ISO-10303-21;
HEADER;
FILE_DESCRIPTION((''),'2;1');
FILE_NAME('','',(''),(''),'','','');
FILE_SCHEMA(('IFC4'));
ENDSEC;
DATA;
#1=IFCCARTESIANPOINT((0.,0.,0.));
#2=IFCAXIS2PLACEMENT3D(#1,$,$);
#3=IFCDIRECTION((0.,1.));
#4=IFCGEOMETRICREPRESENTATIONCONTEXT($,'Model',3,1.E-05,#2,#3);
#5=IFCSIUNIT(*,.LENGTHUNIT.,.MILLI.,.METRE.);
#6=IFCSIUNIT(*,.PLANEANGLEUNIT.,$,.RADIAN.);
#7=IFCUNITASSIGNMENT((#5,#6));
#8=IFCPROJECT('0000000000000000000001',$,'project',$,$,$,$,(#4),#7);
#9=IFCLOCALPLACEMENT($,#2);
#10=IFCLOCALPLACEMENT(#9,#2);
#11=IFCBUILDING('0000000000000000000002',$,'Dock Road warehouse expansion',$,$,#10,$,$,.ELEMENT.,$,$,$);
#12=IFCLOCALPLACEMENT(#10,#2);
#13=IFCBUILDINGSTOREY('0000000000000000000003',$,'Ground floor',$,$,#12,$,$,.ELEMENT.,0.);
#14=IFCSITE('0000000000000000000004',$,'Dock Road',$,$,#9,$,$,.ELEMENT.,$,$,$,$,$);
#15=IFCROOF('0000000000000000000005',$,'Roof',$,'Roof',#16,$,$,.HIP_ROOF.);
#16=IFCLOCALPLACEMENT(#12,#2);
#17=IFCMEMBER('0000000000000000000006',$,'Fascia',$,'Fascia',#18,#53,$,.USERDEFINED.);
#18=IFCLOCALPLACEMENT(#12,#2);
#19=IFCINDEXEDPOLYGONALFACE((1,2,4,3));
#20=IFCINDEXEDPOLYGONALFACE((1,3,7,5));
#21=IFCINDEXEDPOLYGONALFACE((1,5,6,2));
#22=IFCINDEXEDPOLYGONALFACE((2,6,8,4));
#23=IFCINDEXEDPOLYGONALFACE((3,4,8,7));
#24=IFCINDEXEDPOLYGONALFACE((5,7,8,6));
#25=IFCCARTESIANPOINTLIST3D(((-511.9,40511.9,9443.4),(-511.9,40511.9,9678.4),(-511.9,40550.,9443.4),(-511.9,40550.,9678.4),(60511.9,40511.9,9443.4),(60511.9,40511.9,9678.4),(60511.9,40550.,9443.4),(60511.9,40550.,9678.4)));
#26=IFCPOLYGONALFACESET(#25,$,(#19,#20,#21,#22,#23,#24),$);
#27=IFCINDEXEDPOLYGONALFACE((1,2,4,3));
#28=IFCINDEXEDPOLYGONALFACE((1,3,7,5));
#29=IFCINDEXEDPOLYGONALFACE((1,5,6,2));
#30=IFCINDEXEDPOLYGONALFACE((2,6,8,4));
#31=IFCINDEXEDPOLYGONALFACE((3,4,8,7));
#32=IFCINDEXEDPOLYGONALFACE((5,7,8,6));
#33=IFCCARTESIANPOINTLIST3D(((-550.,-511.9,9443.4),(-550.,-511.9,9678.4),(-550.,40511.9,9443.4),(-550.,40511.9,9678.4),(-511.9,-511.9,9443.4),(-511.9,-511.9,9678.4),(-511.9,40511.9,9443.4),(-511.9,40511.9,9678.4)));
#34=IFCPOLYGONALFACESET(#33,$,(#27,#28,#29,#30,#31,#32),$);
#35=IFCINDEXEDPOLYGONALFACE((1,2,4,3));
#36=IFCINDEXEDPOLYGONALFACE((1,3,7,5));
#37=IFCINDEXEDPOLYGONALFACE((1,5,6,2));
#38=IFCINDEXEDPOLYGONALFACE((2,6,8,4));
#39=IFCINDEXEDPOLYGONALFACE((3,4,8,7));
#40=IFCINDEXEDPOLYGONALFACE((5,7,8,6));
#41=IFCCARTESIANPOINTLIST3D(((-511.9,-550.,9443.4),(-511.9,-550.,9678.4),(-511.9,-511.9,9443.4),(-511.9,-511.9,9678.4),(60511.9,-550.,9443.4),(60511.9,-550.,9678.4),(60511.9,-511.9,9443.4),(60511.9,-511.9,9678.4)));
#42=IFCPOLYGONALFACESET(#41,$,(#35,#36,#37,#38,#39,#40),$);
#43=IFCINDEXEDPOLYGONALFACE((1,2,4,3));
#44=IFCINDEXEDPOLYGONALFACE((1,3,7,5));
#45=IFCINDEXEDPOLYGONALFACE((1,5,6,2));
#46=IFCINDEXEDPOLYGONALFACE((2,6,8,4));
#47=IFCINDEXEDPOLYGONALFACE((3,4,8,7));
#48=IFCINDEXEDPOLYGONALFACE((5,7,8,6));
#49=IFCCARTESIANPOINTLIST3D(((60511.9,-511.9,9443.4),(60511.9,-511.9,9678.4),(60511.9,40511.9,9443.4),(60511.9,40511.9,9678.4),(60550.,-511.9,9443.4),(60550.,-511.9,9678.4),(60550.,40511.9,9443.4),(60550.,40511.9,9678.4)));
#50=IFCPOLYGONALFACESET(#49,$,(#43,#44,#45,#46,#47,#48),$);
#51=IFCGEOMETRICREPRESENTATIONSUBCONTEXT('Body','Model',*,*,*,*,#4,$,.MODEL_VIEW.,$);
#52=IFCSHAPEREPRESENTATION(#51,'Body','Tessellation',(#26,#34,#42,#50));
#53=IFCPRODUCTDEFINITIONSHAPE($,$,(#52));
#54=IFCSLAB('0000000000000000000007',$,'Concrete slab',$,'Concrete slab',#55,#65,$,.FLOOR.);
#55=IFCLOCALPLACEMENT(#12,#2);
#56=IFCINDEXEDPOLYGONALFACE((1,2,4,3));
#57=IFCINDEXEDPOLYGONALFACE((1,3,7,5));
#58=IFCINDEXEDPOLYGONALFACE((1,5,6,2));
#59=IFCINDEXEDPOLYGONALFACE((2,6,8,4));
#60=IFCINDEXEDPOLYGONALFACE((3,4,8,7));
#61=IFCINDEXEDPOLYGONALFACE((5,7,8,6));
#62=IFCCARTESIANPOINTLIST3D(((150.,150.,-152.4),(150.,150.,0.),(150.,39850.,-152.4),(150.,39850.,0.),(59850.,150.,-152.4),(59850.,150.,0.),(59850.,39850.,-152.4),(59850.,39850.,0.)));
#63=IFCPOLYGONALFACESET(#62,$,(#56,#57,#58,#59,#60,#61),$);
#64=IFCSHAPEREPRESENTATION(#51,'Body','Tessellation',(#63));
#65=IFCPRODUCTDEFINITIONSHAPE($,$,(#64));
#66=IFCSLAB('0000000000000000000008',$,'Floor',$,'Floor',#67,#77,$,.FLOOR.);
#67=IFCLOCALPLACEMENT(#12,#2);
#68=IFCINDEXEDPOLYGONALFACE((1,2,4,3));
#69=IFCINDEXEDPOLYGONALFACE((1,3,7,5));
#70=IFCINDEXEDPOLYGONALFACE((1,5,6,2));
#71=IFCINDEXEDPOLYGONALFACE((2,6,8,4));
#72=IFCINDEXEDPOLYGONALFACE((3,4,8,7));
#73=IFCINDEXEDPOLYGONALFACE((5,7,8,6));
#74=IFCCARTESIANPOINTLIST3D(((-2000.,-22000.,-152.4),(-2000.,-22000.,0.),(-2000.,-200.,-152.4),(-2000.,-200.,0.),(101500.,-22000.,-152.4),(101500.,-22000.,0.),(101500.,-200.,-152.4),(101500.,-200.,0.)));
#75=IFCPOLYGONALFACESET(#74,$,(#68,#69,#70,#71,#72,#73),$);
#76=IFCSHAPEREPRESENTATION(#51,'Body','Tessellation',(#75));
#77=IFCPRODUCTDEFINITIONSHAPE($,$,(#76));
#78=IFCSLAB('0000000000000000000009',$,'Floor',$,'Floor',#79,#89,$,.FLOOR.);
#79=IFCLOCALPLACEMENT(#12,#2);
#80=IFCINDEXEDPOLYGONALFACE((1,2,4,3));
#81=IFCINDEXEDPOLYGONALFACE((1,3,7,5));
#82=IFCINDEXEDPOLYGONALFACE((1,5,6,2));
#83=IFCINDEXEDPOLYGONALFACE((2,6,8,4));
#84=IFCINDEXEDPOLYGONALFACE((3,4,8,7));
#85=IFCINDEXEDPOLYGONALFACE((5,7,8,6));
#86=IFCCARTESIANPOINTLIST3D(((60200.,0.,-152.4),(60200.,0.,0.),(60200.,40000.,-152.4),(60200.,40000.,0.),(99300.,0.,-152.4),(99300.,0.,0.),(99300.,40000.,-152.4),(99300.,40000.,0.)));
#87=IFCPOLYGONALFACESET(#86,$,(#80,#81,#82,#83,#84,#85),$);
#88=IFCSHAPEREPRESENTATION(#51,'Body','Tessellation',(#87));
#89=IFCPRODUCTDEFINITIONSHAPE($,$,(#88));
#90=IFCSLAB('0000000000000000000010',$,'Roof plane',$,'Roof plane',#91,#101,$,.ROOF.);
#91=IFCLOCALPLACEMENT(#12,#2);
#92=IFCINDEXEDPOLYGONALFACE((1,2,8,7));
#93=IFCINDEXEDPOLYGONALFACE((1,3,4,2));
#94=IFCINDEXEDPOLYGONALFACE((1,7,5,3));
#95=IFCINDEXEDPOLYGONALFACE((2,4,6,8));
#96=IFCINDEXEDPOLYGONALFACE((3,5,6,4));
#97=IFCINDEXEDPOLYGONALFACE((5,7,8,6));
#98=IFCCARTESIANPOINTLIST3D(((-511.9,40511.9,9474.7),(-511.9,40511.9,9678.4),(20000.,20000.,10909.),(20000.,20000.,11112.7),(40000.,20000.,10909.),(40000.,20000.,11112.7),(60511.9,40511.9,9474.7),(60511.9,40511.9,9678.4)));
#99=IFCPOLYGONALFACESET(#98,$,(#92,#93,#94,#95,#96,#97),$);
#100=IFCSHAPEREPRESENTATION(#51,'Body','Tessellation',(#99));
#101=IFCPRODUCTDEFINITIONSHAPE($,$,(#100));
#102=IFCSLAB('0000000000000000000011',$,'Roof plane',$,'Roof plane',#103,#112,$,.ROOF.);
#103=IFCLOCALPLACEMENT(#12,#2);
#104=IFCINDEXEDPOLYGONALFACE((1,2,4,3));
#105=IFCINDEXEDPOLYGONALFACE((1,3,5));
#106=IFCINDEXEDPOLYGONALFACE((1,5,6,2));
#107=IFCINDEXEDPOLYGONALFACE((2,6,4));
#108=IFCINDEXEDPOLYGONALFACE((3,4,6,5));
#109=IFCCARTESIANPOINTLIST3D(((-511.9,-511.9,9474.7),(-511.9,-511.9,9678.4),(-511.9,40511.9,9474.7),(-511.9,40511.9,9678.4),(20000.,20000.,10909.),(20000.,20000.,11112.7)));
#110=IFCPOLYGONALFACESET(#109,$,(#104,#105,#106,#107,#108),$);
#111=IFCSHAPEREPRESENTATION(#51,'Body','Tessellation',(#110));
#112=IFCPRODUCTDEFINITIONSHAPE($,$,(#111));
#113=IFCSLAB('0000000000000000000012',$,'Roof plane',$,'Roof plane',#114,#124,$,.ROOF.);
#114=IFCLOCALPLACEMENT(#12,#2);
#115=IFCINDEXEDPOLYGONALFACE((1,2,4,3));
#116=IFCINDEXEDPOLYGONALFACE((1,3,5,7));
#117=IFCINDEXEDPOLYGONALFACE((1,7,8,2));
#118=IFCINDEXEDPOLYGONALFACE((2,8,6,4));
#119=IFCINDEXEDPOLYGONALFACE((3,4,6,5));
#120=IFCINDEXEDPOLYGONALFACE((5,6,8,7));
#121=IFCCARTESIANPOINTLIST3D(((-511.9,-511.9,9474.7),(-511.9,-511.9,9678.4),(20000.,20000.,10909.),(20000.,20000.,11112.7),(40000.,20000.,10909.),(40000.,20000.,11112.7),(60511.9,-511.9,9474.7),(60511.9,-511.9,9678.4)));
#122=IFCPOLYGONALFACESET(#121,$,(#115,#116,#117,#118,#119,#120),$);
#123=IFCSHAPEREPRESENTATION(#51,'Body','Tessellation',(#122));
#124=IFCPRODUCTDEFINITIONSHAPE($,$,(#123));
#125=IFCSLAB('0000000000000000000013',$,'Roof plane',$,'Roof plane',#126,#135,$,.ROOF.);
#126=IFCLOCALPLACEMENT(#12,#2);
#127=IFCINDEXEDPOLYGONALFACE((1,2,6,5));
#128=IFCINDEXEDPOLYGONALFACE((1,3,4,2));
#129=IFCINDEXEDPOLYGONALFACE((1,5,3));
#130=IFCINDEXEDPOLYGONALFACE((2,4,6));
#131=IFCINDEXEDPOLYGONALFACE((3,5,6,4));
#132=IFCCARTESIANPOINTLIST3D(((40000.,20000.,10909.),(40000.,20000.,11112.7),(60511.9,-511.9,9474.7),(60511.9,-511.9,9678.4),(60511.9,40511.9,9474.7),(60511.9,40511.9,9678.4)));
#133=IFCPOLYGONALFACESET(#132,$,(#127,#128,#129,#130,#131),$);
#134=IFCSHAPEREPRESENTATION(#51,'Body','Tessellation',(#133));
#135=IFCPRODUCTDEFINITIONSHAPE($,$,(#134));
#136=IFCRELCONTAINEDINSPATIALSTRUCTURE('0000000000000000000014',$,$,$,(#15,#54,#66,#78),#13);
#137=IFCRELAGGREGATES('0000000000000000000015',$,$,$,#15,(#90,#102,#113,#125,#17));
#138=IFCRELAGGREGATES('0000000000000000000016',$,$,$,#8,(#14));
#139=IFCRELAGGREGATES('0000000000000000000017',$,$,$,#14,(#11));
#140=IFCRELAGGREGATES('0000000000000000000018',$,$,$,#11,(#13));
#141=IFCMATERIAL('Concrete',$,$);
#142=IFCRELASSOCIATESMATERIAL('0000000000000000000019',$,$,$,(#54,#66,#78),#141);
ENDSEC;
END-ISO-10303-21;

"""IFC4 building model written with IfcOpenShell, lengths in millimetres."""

from ifc_helpers import new_model, si_unit, direction, frame, origin, origin_with_axes, place, context, subcontext, project, spatial, polyline, outline, extrude, material, element, aggregate, save


model = new_model("IFC4")

# Units and contexts
model_context = context("Model", 3, precision=1e-05, world=origin(), true_north=direction((0.0, 1.0)))
body_context = subcontext(model_context, "Body", "Model", "MODEL_VIEW")
ifc_project = project(units=[si_unit("LENGTHUNIT", "METRE", prefix="MILLI"), si_unit("PLANEANGLEUNIT", "RADIAN")], contexts=[model_context])

# Site, building, storey
site_placement = place(None, origin())
site = spatial("IfcSite", under=ifc_project, at=site_placement, Name="Dock Road", CompositionType="ELEMENT")
building_placement = place(site_placement, origin())
building = spatial("IfcBuilding", under=site, at=building_placement, Name="Dock Road warehouse expansion", CompositionType="ELEMENT")
storey_placement = place(building_placement, origin())
storey = spatial("IfcBuildingStorey", under=building, at=storey_placement, Name="Ground floor", CompositionType="ELEMENT", Elevation=0.0)

# Roof, member
roof_placement = place(storey_placement, origin_with_axes())
roof = element("IfcRoof", 1, at=roof_placement, inside=storey, Name="Roof", ObjectType="Roof", PredefinedType="HIP_ROOF")
member_placement = place(storey_placement, origin_with_axes())
member = element("IfcMember", 2, at=member_placement, Name="Fascia", ObjectType="Fascia", PredefinedType="USERDEFINED", context=body_context, shape_type="SweptSolid", body=[
    extrude(outline(polyline([(0.0, -234.9), (61023.8, -234.9), (61023.8, 0.0), (0.0, 0.0), (0.0, -234.9)])), frame((60511.9, 40511.9, 9678.4), z_axis=(0.0, 1.0, 0.0), x_axis=(-1.0, 0.0, 0.0)), (0.0, 0.0, 1.0), 38.1),
    extrude(outline(polyline([(0.0, -234.9), (41023.8, -234.9), (41023.8, 0.0), (0.0, 0.0), (0.0, -234.9)])), frame((-511.9, 40511.9, 9678.4), z_axis=(-1.0, 0.0, 0.0), x_axis=(0.0, -1.0, 0.0)), (0.0, 0.0, 1.0), 38.1),
    extrude(outline(polyline([(0.0, -234.9), (61023.8, -234.9), (61023.8, 0.0), (0.0, 0.0), (0.0, -234.9)])), frame((-511.9, -511.9, 9678.4), z_axis=(0.0, -1.0, 0.0), x_axis=(1.0, 0.0, 0.0)), (0.0, 0.0, 1.0), 38.1),
    extrude(outline(polyline([(0.0, -234.9), (41023.8, -234.9), (41023.8, 0.0), (0.0, 0.0), (0.0, -234.9)])), frame((60511.9, -511.9, 9678.4), z_axis=(1.0, 0.0, 0.0), x_axis=(0.0, 1.0, 0.0)), (0.0, 0.0, 1.0), 38.1),
])

# Slabs
ifc_material_1 = material(Name="Concrete")
slab_1_placement = place(storey_placement, origin_with_axes())
element("IfcSlab", 3, at=slab_1_placement, inside=storey, material=ifc_material_1, Name="Concrete slab", ObjectType="Concrete slab", PredefinedType="FLOOR", context=body_context, shape_type="SweptSolid", body=[
    extrude(outline(polyline([(150.0, 150.0), (59850.0, 150.0), (59850.0, 39850.0), (150.0, 39850.0), (150.0, 150.0)])), frame((0.0, 0.0, -152.4)), (0.0, 0.0, 1.0), 152.4),
])
slab_2_placement = place(storey_placement, origin_with_axes())
element("IfcSlab", 4, at=slab_2_placement, inside=storey, material=ifc_material_1, Name="Floor", ObjectType="Floor", PredefinedType="FLOOR", context=body_context, shape_type="SweptSolid", body=[
    extrude(outline(polyline([(-2000.0, -22000.0), (101500.0, -22000.0), (101500.0, -200.0), (-2000.0, -200.0), (-2000.0, -22000.0)])), frame((0.0, 0.0, -152.4)), (0.0, 0.0, 1.0), 152.4),
])
slab_3_placement = place(storey_placement, origin_with_axes())
element("IfcSlab", 5, at=slab_3_placement, inside=storey, material=ifc_material_1, Name="Floor", ObjectType="Floor", PredefinedType="FLOOR", context=body_context, shape_type="SweptSolid", body=[
    extrude(outline(polyline([(60200.0, 0.0), (99300.0, 0.0), (99300.0, 40000.0), (60200.0, 40000.0), (60200.0, 0.0)])), frame((0.0, 0.0, -152.4)), (0.0, 0.0, 1.0), 152.4),
])

# Slabs
slab_4_placement = place(storey_placement, origin_with_axes())
slab_4 = element("IfcSlab", 6, at=slab_4_placement, Name="Roof plane", ObjectType="Roof plane", PredefinedType="ROOF", context=body_context, shape_type="SweptSolid", body=[
    extrude(outline(polyline([(-60511.9, 0.0), (511.9, 0.0), (-20000.0, 20562.0), (-40000.0, 20562.0), (-60511.9, 0.0)])), frame((0.0, 40511.9, 9474.7), z_axis=(0.0, 0.069756, 0.997564), x_axis=(-1.0, 0.0, 0.0)), (0.0, 0.069756, 0.997564), 203.7),
])
slab_5_placement = place(storey_placement, origin_with_axes())
slab_5 = element("IfcSlab", 7, at=slab_5_placement, Name="Roof plane", ObjectType="Roof plane", PredefinedType="ROOF", context=body_context, shape_type="SweptSolid", body=[
    extrude(outline(polyline([(-40511.9, 0.0), (511.9, 0.0), (-20000.0, 20562.0), (-40511.9, 0.0)])), frame((-511.9, 0.0, 9474.7), z_axis=(-0.069756, 0.0, 0.997564), x_axis=(0.0, -1.0, 0.0)), (0.0, 0.069756, 0.997564), 203.7),
])
slab_6_placement = place(storey_placement, origin_with_axes())
slab_6 = element("IfcSlab", 8, at=slab_6_placement, Name="Roof plane", ObjectType="Roof plane", PredefinedType="ROOF", context=body_context, shape_type="SweptSolid", body=[
    extrude(outline(polyline([(-511.9, 0.0), (60511.9, 0.0), (40000.0, 20562.0), (20000.0, 20562.0), (-511.9, 0.0)])), frame((0.0, -511.9, 9474.7), z_axis=(0.0, -0.069756, 0.997564), x_axis=(1.0, 0.0, 0.0)), (0.0, 0.069756, 0.997564), 203.7),
])
slab_7_placement = place(storey_placement, origin_with_axes())
slab_7 = element("IfcSlab", 9, at=slab_7_placement, Name="Roof plane", ObjectType="Roof plane", PredefinedType="ROOF", context=body_context, shape_type="SweptSolid", body=[
    extrude(outline(polyline([(-511.9, 0.0), (40511.9, 0.0), (20000.0, 20562.0), (-511.9, 0.0)])), frame((60511.9, 0.0, 9474.7), z_axis=(0.069756, 0.0, 0.997564), x_axis=(0.0, 1.0, 0.0)), (0.0, 0.069756, 0.997564), 203.7),
])

aggregate(roof, [slab_4, slab_5, slab_6, slab_7, member])

save(model, "model.ifc")
